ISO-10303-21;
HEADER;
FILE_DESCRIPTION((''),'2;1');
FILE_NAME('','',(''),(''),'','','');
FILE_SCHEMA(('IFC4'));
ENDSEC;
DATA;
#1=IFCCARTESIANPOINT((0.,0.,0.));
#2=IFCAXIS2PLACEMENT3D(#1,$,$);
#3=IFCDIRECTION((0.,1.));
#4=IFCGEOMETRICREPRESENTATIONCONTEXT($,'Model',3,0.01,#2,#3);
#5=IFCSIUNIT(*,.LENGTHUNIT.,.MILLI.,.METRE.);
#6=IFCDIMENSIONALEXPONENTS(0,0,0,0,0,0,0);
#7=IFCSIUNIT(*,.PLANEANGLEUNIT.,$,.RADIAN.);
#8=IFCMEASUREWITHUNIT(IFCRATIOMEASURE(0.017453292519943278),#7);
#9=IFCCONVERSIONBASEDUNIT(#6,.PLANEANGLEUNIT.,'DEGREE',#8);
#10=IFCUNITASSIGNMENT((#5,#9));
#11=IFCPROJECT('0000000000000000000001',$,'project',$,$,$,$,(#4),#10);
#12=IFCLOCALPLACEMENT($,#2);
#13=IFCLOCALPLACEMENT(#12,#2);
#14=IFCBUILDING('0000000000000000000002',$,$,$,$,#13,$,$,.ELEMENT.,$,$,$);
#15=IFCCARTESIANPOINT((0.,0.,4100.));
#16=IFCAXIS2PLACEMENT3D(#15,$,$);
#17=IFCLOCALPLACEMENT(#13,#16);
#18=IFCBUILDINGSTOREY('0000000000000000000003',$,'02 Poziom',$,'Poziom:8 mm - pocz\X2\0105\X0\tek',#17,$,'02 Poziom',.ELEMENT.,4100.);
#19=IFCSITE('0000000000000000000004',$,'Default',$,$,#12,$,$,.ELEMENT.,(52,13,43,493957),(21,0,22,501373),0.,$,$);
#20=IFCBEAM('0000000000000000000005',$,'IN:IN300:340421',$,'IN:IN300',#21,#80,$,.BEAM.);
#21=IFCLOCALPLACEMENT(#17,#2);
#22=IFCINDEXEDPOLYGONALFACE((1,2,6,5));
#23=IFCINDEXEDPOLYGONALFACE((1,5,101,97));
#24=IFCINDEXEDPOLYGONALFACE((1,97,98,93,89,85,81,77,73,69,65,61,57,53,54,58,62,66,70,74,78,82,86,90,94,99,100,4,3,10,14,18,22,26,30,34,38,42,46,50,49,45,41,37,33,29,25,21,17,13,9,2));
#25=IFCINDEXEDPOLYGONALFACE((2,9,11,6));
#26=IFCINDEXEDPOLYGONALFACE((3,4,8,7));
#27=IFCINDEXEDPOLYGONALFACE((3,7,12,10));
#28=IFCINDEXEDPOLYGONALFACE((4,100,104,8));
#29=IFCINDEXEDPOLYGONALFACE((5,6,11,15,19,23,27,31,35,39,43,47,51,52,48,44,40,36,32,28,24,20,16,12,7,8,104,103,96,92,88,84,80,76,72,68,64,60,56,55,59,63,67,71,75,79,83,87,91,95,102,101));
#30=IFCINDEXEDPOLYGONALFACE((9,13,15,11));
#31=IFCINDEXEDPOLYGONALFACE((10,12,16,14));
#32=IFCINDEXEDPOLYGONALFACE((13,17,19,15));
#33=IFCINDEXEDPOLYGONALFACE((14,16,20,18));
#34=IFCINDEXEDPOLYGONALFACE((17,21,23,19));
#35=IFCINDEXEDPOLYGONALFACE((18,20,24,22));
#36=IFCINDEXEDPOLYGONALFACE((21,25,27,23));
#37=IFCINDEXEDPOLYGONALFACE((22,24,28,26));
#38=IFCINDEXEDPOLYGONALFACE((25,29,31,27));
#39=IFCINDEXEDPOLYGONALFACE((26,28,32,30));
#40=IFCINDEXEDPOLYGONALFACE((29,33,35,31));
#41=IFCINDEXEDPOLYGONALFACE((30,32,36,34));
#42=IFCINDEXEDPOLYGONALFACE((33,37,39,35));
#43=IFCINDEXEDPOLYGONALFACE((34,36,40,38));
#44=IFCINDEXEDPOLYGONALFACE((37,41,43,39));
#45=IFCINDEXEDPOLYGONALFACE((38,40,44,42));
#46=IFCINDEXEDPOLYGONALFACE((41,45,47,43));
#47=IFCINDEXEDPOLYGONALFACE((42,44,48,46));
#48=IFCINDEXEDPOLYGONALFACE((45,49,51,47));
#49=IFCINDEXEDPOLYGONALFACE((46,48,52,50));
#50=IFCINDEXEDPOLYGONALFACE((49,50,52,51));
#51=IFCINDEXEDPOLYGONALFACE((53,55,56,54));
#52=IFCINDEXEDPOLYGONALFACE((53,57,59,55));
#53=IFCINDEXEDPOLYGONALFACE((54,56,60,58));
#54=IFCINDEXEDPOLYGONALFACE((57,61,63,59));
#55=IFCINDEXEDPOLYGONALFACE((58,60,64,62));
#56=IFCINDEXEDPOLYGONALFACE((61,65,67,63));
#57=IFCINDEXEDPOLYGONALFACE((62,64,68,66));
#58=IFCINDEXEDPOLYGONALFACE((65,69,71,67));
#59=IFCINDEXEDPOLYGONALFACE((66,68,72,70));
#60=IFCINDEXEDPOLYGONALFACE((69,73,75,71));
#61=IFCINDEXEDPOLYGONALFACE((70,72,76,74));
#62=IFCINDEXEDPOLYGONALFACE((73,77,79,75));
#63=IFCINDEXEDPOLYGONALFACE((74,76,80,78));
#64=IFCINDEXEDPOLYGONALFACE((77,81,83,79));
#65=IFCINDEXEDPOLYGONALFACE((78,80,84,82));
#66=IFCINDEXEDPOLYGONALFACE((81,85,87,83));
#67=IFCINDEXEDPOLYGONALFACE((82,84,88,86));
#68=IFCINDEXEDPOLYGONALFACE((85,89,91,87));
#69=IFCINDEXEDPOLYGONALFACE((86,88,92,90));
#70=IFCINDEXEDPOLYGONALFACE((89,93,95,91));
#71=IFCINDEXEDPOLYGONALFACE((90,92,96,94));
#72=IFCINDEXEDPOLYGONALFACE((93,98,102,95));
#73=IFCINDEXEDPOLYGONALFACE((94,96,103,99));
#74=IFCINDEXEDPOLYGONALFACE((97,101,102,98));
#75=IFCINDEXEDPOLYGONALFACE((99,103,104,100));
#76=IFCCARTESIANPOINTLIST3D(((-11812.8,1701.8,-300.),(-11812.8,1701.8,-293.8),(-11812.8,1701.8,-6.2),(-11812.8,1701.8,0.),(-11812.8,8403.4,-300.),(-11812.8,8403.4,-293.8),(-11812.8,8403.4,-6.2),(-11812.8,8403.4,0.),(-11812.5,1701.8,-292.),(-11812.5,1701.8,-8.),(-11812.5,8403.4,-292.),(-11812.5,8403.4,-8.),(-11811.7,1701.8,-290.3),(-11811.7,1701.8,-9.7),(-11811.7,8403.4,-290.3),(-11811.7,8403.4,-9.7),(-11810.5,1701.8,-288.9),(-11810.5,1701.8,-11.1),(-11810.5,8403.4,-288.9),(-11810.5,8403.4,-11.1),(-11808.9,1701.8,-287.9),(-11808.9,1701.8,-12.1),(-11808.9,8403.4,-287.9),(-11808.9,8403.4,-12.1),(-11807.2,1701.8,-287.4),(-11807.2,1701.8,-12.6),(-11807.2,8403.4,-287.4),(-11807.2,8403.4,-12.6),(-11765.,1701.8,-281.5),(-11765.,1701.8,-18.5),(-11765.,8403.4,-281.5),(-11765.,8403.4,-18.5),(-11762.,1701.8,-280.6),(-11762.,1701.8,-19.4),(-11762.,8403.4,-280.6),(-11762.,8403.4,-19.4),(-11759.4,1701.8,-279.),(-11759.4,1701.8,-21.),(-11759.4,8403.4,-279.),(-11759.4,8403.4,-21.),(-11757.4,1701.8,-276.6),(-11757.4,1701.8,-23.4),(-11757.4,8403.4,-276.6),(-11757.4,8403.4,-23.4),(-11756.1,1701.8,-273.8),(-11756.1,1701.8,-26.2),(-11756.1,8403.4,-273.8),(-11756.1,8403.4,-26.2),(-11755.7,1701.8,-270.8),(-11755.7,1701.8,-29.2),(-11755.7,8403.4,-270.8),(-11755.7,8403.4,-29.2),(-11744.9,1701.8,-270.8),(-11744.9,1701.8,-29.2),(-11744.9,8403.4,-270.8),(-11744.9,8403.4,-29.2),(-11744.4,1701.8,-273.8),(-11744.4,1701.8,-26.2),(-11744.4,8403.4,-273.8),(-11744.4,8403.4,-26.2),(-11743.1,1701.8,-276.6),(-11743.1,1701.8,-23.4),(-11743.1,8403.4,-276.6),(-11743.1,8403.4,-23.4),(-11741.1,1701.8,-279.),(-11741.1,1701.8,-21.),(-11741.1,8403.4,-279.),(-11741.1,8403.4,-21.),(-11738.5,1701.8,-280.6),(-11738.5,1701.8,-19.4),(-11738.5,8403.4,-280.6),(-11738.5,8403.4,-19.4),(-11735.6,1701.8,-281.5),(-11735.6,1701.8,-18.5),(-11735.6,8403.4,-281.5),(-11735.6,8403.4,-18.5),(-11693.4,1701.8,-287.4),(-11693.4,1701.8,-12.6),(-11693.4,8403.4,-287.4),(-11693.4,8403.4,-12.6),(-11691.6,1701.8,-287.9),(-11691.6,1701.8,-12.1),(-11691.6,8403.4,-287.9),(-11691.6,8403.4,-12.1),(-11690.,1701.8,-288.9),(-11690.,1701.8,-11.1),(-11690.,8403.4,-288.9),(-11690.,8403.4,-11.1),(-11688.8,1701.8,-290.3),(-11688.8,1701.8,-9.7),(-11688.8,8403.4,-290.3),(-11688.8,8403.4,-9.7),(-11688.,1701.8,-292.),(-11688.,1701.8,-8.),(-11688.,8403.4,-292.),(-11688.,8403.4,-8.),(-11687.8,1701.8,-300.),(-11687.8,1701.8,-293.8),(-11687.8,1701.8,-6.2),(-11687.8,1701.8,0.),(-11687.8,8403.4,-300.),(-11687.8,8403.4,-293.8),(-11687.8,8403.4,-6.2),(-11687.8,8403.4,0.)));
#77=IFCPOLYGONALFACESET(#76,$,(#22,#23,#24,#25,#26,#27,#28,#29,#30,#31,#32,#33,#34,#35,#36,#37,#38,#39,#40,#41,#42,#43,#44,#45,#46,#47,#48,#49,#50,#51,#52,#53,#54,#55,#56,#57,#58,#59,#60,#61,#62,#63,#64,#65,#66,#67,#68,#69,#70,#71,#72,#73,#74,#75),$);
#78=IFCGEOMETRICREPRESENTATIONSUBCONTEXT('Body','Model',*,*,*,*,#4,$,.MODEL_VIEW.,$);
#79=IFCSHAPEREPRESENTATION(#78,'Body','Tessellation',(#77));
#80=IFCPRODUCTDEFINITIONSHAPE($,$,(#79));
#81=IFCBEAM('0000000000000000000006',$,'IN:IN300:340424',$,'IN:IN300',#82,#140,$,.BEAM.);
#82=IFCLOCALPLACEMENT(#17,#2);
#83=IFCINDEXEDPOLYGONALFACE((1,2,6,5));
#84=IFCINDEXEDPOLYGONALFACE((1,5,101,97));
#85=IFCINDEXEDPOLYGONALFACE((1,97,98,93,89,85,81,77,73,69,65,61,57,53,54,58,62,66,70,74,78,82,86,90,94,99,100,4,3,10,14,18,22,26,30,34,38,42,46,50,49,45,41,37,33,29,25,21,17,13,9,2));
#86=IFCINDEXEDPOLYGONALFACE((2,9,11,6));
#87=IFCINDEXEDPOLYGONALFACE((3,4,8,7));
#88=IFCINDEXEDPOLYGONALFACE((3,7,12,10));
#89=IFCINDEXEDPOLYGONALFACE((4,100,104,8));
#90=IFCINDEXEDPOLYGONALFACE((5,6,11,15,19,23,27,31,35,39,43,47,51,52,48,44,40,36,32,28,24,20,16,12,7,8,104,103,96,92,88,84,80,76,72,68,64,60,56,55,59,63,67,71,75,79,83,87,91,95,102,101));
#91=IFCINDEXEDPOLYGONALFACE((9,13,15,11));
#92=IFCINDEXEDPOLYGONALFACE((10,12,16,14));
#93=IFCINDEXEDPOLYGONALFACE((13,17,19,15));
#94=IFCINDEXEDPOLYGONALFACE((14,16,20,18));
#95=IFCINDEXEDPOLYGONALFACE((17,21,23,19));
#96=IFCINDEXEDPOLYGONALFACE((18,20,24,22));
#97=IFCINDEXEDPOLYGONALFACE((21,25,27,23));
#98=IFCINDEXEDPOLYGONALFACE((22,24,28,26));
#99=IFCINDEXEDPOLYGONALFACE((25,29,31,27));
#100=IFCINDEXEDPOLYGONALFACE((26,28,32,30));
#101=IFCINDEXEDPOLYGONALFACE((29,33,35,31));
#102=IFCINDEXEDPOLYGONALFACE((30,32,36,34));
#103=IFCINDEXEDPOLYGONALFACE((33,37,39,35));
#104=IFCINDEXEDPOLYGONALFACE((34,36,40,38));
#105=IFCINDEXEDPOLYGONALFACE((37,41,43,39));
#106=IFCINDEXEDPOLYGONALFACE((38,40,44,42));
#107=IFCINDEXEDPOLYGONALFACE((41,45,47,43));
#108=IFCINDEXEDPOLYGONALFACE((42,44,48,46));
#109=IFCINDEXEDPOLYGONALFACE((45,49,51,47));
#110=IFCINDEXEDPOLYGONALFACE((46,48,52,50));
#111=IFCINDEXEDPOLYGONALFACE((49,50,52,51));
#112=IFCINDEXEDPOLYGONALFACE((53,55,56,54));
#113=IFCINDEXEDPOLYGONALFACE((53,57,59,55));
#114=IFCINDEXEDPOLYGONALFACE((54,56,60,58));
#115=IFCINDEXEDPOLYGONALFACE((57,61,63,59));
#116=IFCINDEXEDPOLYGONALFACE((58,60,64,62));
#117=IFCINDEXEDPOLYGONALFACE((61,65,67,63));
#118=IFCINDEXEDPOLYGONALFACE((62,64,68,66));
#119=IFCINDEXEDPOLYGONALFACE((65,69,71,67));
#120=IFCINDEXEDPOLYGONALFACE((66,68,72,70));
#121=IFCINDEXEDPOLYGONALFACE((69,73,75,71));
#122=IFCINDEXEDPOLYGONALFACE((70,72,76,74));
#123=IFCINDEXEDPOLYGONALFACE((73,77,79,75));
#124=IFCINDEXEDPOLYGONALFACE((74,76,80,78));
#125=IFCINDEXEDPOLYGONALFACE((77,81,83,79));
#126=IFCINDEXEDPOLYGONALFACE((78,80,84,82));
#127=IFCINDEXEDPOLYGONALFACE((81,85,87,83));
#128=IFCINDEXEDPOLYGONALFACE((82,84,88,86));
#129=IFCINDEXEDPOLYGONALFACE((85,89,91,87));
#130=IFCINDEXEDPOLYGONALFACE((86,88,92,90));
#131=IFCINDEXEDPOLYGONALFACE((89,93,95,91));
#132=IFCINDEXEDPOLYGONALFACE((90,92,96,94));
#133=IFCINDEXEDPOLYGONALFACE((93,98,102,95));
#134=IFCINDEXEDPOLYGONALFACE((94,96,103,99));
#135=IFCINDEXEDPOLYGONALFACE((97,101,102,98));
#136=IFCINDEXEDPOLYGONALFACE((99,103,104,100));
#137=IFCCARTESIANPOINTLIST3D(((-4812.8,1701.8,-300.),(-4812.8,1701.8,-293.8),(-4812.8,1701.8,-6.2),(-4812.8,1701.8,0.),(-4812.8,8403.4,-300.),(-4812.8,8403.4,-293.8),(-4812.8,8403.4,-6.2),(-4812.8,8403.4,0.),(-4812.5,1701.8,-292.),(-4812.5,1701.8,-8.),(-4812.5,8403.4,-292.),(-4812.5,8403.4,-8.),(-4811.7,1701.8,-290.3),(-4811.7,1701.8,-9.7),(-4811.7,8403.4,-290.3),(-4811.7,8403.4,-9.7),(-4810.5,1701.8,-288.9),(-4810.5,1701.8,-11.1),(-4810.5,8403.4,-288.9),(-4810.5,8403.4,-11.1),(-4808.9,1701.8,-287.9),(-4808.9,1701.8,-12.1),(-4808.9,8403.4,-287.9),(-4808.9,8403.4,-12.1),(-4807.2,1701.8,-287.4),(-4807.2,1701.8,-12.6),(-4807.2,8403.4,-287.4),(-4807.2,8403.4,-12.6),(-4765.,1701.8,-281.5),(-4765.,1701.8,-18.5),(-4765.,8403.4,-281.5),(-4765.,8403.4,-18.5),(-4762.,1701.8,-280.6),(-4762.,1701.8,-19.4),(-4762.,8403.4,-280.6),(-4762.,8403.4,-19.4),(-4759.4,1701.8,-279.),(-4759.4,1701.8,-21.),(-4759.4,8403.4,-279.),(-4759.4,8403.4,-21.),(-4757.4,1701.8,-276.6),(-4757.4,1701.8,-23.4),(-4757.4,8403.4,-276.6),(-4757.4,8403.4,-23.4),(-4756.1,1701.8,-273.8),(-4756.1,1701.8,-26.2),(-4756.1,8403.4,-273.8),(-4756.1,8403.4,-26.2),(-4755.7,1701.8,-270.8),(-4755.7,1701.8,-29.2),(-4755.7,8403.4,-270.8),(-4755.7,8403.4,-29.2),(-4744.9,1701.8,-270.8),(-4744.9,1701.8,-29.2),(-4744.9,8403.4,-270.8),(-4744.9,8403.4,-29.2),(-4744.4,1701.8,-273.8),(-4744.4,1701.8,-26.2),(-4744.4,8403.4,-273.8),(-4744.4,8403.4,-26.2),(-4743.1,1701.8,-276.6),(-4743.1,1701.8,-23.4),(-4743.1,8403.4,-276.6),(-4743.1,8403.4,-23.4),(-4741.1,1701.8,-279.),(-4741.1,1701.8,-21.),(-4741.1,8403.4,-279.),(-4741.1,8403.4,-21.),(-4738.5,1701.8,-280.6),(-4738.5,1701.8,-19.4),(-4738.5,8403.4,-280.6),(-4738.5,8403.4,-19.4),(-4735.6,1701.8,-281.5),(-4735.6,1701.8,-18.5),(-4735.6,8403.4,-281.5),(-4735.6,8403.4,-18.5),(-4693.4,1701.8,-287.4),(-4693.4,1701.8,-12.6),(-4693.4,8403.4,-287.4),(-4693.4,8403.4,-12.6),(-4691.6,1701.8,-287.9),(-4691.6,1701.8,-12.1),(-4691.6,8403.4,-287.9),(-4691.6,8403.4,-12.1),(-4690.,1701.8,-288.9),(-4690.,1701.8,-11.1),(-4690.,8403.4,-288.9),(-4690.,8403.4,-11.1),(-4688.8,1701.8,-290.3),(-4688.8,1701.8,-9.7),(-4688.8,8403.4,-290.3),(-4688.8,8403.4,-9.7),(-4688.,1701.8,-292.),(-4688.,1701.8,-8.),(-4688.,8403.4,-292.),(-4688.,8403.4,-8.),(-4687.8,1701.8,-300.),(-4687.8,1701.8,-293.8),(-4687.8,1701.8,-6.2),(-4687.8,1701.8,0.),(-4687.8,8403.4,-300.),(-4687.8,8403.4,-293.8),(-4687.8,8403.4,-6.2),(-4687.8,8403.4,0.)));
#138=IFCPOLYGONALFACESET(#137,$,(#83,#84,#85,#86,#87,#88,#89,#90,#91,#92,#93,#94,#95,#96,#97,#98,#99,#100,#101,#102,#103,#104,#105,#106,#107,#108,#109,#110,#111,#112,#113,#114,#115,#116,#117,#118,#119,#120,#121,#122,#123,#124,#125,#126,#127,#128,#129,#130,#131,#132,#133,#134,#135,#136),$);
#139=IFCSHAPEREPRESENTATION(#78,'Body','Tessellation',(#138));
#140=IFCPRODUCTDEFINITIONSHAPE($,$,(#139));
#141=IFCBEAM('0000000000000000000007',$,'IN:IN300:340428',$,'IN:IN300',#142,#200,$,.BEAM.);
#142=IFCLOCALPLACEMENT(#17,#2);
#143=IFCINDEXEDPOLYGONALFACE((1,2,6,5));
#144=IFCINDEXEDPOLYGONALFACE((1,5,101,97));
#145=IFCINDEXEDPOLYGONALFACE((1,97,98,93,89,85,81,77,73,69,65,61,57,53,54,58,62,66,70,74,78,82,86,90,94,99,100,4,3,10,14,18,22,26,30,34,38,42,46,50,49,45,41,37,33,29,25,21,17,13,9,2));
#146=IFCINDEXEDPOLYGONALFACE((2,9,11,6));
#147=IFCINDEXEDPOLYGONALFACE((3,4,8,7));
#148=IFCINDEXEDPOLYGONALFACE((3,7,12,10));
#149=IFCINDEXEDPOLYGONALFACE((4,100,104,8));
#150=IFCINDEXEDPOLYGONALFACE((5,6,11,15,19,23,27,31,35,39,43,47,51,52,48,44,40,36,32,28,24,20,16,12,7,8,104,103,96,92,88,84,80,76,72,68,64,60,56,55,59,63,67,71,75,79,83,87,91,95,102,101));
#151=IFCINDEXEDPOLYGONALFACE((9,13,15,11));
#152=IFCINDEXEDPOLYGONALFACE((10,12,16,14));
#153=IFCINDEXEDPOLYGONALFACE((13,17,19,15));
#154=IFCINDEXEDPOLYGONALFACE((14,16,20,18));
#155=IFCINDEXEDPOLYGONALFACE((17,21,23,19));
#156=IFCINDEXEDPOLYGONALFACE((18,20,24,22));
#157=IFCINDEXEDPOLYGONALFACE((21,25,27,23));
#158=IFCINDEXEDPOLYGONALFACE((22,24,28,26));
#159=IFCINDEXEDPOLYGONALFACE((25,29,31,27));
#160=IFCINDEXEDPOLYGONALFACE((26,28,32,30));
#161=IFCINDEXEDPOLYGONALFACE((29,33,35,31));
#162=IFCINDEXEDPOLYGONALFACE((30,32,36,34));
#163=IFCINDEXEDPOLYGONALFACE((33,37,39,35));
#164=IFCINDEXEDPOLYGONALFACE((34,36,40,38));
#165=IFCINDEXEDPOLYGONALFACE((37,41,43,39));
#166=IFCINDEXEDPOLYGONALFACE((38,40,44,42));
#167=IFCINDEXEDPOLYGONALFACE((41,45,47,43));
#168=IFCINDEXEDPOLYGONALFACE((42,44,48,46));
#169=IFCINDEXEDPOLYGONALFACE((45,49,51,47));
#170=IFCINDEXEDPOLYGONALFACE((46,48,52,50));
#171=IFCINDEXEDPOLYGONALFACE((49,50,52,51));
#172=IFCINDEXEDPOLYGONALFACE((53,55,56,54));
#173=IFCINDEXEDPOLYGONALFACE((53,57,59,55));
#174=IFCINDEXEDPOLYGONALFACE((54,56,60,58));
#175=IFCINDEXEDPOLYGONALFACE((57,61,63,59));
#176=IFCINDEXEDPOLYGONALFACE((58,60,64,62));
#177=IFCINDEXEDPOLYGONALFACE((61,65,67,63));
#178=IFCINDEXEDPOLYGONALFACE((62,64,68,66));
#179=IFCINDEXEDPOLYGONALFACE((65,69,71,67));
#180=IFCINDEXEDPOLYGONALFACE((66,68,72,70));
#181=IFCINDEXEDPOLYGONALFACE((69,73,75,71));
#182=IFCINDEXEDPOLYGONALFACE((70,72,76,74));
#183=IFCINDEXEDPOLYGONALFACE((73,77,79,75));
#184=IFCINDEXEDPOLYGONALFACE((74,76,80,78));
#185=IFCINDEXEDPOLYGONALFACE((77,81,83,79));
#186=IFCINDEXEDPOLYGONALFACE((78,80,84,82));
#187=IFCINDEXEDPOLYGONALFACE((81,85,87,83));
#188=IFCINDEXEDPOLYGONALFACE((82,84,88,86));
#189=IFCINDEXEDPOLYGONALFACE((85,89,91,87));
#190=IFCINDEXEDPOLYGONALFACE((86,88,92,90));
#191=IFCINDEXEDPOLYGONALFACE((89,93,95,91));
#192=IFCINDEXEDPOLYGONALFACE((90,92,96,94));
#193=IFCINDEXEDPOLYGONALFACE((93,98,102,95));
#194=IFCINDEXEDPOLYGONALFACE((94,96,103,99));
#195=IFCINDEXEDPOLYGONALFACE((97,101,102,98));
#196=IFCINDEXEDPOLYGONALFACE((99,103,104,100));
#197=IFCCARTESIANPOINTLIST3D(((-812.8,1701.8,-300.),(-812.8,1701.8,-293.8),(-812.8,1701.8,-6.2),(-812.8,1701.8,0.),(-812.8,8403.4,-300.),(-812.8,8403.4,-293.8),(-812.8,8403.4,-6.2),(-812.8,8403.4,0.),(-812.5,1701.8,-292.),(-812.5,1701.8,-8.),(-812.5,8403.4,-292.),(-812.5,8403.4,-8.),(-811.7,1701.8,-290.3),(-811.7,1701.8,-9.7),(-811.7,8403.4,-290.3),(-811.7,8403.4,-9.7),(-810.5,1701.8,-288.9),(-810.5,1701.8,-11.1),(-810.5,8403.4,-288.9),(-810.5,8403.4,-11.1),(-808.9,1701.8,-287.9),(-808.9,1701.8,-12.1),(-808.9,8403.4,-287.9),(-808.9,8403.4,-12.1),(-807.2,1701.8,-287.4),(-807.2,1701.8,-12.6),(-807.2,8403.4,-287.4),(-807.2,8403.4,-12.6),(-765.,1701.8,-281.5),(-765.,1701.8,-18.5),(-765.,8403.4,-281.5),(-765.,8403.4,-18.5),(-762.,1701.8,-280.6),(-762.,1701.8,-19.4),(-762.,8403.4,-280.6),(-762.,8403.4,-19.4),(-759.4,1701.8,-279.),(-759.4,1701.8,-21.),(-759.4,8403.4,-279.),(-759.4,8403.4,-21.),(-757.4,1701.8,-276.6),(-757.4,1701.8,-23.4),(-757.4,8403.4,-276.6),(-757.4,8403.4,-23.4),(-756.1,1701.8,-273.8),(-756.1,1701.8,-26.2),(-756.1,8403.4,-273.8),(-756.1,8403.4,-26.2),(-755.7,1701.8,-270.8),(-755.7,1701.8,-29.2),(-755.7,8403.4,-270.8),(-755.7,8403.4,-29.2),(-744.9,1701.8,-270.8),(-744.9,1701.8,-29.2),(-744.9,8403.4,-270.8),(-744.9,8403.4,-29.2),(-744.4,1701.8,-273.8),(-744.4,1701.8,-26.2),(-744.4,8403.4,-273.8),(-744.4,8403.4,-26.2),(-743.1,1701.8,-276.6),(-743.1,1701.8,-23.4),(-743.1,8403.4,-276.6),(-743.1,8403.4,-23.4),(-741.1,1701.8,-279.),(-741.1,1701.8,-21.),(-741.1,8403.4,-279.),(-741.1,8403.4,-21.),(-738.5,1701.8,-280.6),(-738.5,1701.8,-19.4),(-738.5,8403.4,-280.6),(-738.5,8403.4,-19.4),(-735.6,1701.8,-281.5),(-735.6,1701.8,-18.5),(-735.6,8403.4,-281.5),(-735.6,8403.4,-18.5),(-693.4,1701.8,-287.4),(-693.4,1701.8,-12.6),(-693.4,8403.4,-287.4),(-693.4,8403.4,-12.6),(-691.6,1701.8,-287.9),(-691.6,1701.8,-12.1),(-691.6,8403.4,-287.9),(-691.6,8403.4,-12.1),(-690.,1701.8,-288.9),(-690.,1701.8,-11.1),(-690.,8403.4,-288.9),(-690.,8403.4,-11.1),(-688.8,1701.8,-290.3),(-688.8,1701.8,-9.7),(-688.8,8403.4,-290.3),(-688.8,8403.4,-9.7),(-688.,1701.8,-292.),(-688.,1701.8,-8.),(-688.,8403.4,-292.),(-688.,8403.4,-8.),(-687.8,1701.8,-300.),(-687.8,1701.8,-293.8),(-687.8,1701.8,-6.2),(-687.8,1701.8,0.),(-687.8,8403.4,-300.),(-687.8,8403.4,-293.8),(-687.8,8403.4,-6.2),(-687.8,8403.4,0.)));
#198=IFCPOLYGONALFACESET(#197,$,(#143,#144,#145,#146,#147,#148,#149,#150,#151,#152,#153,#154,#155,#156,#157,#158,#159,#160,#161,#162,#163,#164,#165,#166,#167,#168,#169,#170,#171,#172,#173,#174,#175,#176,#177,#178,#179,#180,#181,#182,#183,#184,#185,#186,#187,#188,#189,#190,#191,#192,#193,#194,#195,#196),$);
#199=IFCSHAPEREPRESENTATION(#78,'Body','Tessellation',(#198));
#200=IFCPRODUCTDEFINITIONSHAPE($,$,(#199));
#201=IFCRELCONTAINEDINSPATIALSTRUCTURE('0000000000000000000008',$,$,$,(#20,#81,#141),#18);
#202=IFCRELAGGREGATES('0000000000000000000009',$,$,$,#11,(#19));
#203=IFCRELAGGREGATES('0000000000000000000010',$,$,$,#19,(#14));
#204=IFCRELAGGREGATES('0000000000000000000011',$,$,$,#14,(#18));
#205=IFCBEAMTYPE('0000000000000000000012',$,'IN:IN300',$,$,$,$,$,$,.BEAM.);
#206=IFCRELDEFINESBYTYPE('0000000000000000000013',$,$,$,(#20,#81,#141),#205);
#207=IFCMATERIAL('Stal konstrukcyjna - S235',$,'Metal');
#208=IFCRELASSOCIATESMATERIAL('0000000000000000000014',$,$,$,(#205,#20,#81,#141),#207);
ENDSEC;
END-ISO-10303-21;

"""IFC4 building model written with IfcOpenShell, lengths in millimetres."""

from ifc_helpers import new_model, entity, si_unit, converted_unit, direction, frame, origin, place, context, subcontext, project, spatial, line, arc, indexed_curve, outline, extrude, source, transform, mapped, material, type_object, type_shapes, element, save


model = new_model("IFC4")

# Units and contexts
model_context = context("Model", 3, precision=0.01, world=origin(), true_north=direction((0.0, 1.0)))
body_context = subcontext(model_context, "Body", "Model", "MODEL_VIEW")
ifc_project = project(units=[si_unit("LENGTHUNIT", "METRE", prefix="MILLI"), converted_unit("PLANEANGLEUNIT", "DEGREE", entity("IfcRatioMeasure", 0.017453292519943278), si_unit("PLANEANGLEUNIT", "RADIAN"), dimensions=[0, 0, 0, 0, 0, 0, 0])], contexts=[model_context])

# Site, building, storey
site_placement = place(None, origin())
site = spatial("IfcSite", under=ifc_project, at=site_placement, Name="Default", CompositionType="ELEMENT", RefLatitude=(52, 13, 43, 493957), RefLongitude=(21, 0, 22, 501373), RefElevation=0.0)
building_placement = place(site_placement, origin())
building = spatial("IfcBuilding", under=site, at=building_placement, CompositionType="ELEMENT")
storey_placement = place(building_placement, frame((0.0, 0.0, 4100.0)))
storey = spatial("IfcBuildingStorey", under=building, at=storey_placement, Name="02 Poziom", ObjectType="Poziom:8 mm - początek", LongName="02 Poziom", CompositionType="ELEMENT", Elevation=4100.0)

# Shared definitions
ifc_material_1 = material(Name="Stal konstrukcyjna - S235", Category="Metal")

# Beams
beam_type_1 = type_object("IfcBeamType", Name="IN:IN300", PredefinedType="BEAM", material=ifc_material_1)
shared_shape_1 = source(origin(), body_context, "Body", "SweptSolid", [
    extrude(outline(indexed_curve([(143.8, -62.5), (150.0, -62.5), (150.0, 62.5), (143.8, 62.5), (139.6, 60.9), (137.4, 56.9), (131.5, 14.7), (127.9, 8.1), (120.8, 5.4), (-120.8, 5.4), (-127.9, 8.1), (-131.5, 14.7), (-137.4, 56.9), (-139.6, 60.9), (-143.8, 62.5), (-150.0, 62.5), (-150.0, -62.5), (-143.8, -62.5), (-139.6, -60.9), (-137.4, -56.9), (-131.5, -14.7), (-127.9, -8.1), (-120.8, -5.4), (120.8, -5.4), (127.9, -8.1), (131.5, -14.7), (137.4, -56.9), (139.6, -60.9)], segments=[line(1, 2, 3, 4), arc(4, 5, 6), line(6, 7), arc(7, 8, 9), line(9, 10), arc(10, 11, 12), line(12, 13), arc(13, 14, 15), line(15, 16, 17, 18), arc(18, 19, 20), line(20, 21), arc(21, 22, 23), line(23, 24), arc(24, 25, 26), line(26, 27), arc(27, 28, 1)], self_intersect=False)), frame((-3350.8, 0.0, 0.0), z_axis=(1.0, 0.0, 0.0), x_axis=(0.0, 0.0, -1.0)), (0.0, 0.0, 1.0), 6701.6),
])
type_shapes(beam_type_1, [shared_shape_1])
for number, where, z_axis, x_axis, name in (
    (1, (-11750.3, 5052.6, -150.0), (0.0, 0.0, 1.0), (0.0, -1.0, 0.0), "IN:IN300:340421"),
    (2, (-4750.3, 5052.6, -150.0), (0.0, 0.0, 1.0), (0.0, -1.0, 0.0), "IN:IN300:340424"),
    (3, (-750.3, 5052.6, -150.0), (0.0, 0.0, 1.0), (0.0, -1.0, 0.0), "IN:IN300:340428"),
):
    element("IfcBeam", number, at=place(storey_placement, frame(where, z_axis=z_axis, x_axis=x_axis)), inside=storey, type_object=beam_type_1, material=ifc_material_1, Name=name, ObjectType="IN:IN300", PredefinedType="BEAM", context=body_context, shape_type="MappedRepresentation", body=[
        mapped(shared_shape_1, transform((0.0, 0.0, 0.0), scale=1.0)),
    ])

save(model, "model.ifc")
